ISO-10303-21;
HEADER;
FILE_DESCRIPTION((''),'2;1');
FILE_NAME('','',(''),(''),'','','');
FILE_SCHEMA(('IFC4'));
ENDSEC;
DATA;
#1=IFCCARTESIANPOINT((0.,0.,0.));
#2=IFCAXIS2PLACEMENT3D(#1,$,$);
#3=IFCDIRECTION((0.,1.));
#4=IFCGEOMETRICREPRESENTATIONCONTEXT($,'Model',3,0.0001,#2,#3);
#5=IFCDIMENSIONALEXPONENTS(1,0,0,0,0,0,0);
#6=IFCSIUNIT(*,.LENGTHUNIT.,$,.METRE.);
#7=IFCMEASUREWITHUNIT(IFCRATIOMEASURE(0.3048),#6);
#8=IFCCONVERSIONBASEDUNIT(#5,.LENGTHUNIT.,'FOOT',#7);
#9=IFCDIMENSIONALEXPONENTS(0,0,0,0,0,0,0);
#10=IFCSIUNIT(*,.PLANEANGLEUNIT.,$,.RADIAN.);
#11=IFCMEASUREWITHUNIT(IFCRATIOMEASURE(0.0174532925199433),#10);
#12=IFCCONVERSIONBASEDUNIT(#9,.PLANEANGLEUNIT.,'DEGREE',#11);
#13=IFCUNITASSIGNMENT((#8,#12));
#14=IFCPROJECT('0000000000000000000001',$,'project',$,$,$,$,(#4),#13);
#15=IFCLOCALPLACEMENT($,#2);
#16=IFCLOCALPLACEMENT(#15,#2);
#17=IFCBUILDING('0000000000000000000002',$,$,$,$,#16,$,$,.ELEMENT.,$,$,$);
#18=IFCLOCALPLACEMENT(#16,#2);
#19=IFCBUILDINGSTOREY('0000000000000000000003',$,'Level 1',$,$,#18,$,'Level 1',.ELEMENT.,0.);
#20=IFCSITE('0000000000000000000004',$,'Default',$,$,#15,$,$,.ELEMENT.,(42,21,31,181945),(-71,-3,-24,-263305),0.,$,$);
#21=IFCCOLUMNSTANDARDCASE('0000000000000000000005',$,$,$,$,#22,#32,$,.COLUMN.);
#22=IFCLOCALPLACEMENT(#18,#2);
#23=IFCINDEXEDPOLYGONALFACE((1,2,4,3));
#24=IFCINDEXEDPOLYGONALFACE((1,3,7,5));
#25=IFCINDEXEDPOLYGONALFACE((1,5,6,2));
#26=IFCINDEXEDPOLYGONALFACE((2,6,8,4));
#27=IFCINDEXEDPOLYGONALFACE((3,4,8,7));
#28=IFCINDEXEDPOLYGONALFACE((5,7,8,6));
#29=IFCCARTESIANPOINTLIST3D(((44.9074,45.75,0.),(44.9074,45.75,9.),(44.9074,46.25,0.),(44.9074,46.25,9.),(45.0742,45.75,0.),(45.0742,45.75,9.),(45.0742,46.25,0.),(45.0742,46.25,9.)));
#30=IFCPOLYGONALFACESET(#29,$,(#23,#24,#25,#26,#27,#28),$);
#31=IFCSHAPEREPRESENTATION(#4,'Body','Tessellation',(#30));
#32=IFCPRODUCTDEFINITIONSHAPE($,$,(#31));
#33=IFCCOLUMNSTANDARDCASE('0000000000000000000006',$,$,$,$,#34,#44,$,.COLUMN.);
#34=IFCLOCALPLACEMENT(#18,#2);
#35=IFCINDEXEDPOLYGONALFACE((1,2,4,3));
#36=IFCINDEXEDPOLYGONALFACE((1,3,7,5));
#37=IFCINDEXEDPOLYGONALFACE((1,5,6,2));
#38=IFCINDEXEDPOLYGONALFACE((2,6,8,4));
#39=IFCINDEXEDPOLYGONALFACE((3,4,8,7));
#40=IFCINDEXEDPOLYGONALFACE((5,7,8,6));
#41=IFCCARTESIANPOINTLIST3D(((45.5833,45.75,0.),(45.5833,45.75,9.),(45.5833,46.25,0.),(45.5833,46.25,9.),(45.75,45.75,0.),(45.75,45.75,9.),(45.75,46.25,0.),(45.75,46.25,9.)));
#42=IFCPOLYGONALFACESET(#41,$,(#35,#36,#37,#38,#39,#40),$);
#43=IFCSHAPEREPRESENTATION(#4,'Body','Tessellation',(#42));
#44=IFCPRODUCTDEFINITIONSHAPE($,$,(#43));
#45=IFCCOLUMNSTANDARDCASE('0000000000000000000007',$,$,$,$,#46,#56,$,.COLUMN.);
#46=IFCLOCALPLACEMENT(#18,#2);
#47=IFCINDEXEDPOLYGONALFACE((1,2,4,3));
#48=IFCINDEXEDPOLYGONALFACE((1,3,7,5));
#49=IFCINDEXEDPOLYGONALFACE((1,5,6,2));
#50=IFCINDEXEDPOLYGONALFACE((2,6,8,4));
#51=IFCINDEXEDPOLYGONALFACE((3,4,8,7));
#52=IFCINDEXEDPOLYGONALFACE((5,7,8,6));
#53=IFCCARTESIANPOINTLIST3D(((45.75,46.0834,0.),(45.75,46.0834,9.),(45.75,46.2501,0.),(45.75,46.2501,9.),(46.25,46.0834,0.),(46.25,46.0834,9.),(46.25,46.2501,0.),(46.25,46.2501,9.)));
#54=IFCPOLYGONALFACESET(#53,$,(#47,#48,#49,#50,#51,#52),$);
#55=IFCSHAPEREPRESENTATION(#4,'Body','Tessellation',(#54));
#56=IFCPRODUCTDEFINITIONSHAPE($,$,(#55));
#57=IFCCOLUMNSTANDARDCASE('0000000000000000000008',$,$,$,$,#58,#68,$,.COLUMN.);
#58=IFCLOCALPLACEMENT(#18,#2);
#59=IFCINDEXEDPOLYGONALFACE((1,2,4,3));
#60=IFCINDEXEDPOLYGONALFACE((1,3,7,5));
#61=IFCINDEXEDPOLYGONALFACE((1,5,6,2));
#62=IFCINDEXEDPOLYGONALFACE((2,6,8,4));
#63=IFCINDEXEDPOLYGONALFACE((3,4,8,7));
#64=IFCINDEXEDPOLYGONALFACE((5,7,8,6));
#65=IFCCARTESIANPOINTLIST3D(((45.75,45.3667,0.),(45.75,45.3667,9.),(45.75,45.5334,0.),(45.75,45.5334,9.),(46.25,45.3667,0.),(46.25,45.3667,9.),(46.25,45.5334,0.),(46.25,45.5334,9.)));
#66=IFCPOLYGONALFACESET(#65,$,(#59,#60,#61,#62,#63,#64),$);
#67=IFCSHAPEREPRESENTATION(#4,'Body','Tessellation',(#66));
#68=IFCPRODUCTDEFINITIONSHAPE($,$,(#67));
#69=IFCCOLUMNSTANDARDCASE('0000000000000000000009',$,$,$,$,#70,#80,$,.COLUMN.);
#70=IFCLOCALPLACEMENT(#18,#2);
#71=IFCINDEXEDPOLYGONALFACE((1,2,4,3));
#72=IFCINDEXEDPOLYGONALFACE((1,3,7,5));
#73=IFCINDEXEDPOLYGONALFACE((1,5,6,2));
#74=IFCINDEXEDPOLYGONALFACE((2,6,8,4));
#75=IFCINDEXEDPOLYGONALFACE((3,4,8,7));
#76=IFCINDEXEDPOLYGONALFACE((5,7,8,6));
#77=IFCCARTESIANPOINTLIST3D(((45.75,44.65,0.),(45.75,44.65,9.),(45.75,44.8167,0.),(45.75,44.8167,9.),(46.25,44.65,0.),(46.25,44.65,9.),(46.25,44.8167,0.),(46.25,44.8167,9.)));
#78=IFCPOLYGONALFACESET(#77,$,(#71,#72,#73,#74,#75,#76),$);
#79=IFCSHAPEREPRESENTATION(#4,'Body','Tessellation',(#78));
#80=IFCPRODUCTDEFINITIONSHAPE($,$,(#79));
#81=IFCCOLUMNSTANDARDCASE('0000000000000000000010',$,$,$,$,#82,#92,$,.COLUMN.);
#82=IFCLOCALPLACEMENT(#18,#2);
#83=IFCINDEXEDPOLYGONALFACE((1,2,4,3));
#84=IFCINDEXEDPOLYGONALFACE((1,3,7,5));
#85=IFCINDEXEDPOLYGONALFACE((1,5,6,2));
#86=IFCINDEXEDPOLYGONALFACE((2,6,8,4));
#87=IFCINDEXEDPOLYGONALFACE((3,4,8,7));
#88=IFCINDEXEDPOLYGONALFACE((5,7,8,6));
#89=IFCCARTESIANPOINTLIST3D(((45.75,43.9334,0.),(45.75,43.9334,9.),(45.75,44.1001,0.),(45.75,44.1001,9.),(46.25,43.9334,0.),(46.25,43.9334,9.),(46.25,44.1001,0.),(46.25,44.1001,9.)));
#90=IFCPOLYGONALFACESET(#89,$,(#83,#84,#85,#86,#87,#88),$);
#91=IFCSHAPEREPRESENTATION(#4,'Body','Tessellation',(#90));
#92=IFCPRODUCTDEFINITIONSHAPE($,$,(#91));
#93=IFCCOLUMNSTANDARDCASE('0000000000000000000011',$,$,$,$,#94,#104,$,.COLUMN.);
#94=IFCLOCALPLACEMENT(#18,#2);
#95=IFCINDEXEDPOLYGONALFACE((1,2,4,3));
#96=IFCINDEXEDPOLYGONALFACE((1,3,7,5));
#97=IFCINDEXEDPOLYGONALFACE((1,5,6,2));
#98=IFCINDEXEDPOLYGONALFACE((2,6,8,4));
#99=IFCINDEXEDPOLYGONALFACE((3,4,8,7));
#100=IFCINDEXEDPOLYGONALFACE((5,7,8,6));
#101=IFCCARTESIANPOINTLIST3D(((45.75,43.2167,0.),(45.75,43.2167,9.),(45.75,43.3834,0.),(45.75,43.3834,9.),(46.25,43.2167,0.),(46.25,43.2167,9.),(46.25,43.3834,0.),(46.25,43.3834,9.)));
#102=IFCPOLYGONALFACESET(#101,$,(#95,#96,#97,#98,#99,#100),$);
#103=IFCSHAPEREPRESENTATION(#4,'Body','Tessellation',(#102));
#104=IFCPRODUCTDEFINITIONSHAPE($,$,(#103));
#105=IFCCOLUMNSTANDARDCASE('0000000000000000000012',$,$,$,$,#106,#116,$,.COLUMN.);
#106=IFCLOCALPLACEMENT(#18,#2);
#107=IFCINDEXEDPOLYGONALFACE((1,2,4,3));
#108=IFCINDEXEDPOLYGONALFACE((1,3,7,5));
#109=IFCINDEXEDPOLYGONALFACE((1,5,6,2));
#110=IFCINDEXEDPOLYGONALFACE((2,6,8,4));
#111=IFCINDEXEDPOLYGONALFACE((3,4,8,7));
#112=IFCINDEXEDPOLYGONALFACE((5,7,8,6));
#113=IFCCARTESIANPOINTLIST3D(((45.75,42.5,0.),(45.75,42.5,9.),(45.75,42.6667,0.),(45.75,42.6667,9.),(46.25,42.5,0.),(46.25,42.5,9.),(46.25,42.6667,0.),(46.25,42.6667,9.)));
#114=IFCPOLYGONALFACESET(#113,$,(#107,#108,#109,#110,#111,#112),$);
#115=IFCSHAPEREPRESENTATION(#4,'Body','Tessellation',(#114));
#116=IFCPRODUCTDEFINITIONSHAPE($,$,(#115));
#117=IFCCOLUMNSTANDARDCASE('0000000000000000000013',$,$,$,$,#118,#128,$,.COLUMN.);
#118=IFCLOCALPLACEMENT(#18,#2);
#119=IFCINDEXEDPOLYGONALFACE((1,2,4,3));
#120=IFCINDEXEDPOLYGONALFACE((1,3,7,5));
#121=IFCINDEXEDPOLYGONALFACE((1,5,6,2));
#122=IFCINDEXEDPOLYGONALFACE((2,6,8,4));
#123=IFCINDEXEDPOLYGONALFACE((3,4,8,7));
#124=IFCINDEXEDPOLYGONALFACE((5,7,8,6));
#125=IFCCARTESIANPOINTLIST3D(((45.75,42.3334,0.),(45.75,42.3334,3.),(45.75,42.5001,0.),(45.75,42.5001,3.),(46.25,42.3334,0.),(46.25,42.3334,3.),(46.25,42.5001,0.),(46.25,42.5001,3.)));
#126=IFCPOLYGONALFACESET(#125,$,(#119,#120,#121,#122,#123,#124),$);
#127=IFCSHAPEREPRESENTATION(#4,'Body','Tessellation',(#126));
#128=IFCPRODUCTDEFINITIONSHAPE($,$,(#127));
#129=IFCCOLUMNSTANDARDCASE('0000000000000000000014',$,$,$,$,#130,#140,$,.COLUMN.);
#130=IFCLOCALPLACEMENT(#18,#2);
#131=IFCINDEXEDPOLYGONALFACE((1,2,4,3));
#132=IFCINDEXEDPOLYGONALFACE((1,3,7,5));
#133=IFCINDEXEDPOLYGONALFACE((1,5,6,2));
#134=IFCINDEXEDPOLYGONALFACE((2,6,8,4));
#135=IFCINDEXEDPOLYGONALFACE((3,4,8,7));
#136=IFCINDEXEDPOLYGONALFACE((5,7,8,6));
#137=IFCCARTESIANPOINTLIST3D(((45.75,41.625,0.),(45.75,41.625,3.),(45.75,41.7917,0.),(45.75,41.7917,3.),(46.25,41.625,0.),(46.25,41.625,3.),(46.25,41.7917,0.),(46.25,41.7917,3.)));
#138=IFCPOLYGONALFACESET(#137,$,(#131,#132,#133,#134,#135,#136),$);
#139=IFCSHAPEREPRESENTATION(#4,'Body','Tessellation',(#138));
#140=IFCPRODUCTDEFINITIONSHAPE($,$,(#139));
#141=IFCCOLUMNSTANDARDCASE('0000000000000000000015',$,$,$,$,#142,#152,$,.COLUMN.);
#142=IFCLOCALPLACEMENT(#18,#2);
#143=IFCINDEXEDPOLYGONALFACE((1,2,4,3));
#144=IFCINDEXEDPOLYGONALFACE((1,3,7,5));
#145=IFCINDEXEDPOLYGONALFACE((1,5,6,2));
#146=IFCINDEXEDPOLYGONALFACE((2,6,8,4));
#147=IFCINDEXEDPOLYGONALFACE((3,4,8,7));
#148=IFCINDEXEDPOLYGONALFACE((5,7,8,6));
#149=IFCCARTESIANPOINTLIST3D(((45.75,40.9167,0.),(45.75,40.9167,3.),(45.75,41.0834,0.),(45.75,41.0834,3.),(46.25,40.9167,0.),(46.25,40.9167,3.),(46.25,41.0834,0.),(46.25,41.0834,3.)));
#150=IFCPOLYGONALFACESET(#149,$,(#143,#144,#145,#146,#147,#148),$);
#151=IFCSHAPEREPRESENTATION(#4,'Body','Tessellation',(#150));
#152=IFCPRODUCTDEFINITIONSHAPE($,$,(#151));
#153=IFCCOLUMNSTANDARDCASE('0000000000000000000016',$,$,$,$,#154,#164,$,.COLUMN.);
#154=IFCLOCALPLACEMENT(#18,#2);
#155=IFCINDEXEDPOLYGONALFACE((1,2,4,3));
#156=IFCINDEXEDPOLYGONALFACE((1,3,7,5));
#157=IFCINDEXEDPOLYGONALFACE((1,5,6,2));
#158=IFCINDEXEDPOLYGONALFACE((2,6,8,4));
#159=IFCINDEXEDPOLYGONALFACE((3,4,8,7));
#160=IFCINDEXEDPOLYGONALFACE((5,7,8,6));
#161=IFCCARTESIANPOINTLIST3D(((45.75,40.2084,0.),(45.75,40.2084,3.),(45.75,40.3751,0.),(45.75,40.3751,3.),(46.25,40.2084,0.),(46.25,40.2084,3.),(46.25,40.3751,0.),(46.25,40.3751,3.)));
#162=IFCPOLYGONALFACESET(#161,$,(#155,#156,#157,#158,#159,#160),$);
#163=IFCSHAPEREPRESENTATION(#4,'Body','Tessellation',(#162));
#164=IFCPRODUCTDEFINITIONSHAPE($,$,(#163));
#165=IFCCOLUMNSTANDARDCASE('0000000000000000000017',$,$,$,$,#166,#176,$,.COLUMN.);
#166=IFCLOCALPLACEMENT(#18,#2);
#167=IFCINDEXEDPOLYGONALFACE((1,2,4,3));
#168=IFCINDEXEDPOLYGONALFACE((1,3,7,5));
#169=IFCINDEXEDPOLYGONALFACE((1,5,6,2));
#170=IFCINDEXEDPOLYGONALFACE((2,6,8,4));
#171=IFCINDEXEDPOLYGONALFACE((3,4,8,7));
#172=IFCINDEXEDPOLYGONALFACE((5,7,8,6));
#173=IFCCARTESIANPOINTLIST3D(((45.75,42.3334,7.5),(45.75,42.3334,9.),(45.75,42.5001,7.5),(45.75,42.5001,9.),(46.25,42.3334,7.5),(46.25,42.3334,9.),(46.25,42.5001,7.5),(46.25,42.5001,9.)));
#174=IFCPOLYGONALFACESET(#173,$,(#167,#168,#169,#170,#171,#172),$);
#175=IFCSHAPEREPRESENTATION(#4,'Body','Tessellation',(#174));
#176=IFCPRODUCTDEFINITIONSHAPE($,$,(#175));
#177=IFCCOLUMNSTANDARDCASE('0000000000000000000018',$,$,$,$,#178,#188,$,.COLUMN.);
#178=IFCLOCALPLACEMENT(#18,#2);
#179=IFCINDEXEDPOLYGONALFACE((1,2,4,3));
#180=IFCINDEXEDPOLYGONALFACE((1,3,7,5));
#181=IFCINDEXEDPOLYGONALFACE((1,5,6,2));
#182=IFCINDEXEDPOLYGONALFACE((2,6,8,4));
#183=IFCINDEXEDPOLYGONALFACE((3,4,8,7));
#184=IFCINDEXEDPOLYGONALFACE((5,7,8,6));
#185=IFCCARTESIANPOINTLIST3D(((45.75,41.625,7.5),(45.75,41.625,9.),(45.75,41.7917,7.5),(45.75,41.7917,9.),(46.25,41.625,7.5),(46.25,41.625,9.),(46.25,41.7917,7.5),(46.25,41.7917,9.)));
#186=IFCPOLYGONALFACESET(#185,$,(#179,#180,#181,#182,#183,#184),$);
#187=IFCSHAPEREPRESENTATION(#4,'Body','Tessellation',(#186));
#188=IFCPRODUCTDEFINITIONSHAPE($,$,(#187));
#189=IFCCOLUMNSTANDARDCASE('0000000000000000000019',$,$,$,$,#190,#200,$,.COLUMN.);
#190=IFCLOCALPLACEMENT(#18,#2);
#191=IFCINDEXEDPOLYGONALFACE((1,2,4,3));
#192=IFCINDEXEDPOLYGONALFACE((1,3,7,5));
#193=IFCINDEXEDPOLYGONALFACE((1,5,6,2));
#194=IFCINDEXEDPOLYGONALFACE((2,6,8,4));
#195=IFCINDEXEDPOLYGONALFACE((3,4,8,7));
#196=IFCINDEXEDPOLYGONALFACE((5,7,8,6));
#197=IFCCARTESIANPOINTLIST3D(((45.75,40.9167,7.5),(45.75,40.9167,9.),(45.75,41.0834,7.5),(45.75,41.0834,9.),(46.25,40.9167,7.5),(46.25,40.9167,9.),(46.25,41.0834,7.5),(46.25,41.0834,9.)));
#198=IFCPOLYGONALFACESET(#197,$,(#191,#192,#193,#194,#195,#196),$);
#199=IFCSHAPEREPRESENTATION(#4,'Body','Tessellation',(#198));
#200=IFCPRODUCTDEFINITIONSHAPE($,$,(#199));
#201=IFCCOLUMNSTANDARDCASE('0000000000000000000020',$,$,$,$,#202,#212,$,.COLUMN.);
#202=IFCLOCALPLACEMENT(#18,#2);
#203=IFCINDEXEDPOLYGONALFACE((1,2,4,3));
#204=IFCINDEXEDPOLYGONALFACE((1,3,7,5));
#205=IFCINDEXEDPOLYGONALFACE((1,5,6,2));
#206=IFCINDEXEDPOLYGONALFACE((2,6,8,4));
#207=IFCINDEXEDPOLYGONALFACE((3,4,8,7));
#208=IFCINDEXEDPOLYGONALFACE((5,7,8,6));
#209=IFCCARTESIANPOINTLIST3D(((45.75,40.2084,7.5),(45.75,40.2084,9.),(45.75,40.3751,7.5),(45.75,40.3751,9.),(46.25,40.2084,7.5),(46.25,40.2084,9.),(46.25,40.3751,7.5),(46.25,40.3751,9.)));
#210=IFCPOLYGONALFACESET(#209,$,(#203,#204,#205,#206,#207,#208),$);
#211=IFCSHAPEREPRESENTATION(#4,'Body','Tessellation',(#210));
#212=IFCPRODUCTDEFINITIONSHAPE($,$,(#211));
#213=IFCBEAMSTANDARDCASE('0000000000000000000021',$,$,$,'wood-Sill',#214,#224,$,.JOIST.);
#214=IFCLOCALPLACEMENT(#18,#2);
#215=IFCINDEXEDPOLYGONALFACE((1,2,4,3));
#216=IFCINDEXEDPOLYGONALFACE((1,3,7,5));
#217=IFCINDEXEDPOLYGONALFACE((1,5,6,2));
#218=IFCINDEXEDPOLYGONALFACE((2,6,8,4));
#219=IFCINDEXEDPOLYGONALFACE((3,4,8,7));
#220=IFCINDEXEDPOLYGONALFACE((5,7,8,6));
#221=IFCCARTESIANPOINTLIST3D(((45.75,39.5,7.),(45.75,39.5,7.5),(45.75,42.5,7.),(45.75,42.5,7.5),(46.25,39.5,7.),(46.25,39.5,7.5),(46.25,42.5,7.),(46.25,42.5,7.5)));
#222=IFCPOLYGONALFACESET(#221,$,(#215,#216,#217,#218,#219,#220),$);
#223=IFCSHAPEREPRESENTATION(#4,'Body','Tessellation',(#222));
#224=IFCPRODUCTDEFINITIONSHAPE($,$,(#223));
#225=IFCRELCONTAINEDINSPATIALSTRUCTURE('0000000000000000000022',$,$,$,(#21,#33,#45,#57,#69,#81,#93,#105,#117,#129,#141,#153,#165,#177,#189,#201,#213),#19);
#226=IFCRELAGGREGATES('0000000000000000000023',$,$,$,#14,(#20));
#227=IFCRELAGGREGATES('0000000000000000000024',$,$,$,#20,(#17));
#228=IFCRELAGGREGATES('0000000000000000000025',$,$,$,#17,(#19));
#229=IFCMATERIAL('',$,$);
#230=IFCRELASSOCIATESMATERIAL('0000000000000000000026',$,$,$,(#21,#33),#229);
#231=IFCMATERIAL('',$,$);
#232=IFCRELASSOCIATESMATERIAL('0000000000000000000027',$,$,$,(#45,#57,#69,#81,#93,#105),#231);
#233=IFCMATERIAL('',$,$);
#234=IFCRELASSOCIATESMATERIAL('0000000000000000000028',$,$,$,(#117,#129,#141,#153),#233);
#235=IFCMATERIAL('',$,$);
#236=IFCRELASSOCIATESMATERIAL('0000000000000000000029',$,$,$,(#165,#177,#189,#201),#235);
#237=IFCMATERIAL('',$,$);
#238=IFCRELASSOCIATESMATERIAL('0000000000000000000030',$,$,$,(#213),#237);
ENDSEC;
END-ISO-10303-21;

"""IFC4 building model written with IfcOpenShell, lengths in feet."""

from ifc_helpers import new_model, entity, si_unit, converted_unit, direction, frame, origin, place, context, project, spatial, rectangle, extrude, material, element, save


model = new_model("IFC4")

# Units and contexts
model_context = context("Model", 3, precision=0.0001, world=origin(), true_north=direction((0.0, 1.0)))
ifc_project = project(units=[converted_unit("LENGTHUNIT", "FOOT", entity("IfcRatioMeasure", 0.3048), si_unit("LENGTHUNIT", "METRE"), dimensions=[1, 0, 0, 0, 0, 0, 0]), converted_unit("PLANEANGLEUNIT", "DEGREE", entity("IfcRatioMeasure", 0.0174532925199433), si_unit("PLANEANGLEUNIT", "RADIAN"), dimensions=[0, 0, 0, 0, 0, 0, 0])], contexts=[model_context])

# Site, building, storey
site_placement = place(None, origin())
site = spatial("IfcSite", under=ifc_project, at=site_placement, Name="Default", CompositionType="ELEMENT", RefLatitude=(42, 21, 31, 181945), RefLongitude=(-71, -3, -24, -263305), RefElevation=0.0)
building_placement = place(site_placement, origin())
building = spatial("IfcBuilding", under=site, at=building_placement, CompositionType="ELEMENT")
storey_placement = place(building_placement, origin())
storey = spatial("IfcBuildingStorey", under=building, at=storey_placement, Name="Level 1", LongName="Level 1", CompositionType="ELEMENT", Elevation=0.0)

# Columns
ifc_material_1 = material(Name="")
placement_1 = place(storey_placement, frame((-0.25, 46.0, 0.0)))
for number, where, z_axis, x_axis in (
    (1, (45.2408, 0.0, 0.0), (0.0, 0.0, 1.0), (1.0, 0.0, 0.0)),
    (2, (45.9167, 0.0, 0.0), (0.0, 0.0, 1.0), (1.0, 0.0, 0.0)),
):
    element("IfcColumnStandardCase", number, at=place(placement_1, frame(where, z_axis=z_axis, x_axis=x_axis)), inside=storey, material=ifc_material_1, PredefinedType="COLUMN", context=model_context, shape_type="SweptSolid", body=[
        extrude(rectangle(XDim=0.1667, YDim=0.5), origin(), (0.0, 0.0, 1.0), 9.0),
    ])
ifc_material_2 = material(Name="")
placement_2 = place(storey_placement, frame((46.0, 46.25, 0.0), z_axis=(0.0, 0.0, 1.0), x_axis=(0.0, -1.0, 0.0)))
for number, where, z_axis, x_axis in (
    (3, (0.0833, 0.0, 0.0), (0.0, 0.0, 1.0), (1.0, 0.0, 0.0)),
    (4, (0.8, 0.0, 0.0), (0.0, 0.0, 1.0), (1.0, 0.0, 0.0)),
    (5, (1.5167, 0.0, 0.0), (0.0, 0.0, 1.0), (1.0, 0.0, 0.0)),
    (6, (2.2333, 0.0, 0.0), (0.0, 0.0, 1.0), (1.0, 0.0, 0.0)),
    (7, (2.95, 0.0, 0.0), (0.0, 0.0, 1.0), (1.0, 0.0, 0.0)),
    (8, (3.6667, 0.0, 0.0), (0.0, 0.0, 1.0), (1.0, 0.0, 0.0)),
):
    element("IfcColumnStandardCase", number, at=place(placement_2, frame(where, z_axis=z_axis, x_axis=x_axis)), inside=storey, material=ifc_material_2, PredefinedType="COLUMN", context=model_context, shape_type="SweptSolid", body=[
        extrude(rectangle(XDim=0.1667, YDim=0.5), origin(), (0.0, 0.0, 1.0), 9.0),
    ])
ifc_material_3 = material(Name="")
for number, where, z_axis, x_axis in (
    (9, (3.8333, 0.0, 0.0), (0.0, 0.0, 1.0), (1.0, 0.0, 0.0)),
    (10, (4.5417, 0.0, 0.0), (0.0, 0.0, 1.0), (1.0, 0.0, 0.0)),
    (11, (5.25, 0.0, 0.0), (0.0, 0.0, 1.0), (1.0, 0.0, 0.0)),
    (12, (5.9583, 0.0, 0.0), (0.0, 0.0, 1.0), (1.0, 0.0, 0.0)),
):
    element("IfcColumnStandardCase", number, at=place(placement_2, frame(where, z_axis=z_axis, x_axis=x_axis)), inside=storey, material=ifc_material_3, PredefinedType="COLUMN", context=model_context, shape_type="SweptSolid", body=[
        extrude(rectangle(XDim=0.1667, YDim=0.5), origin(), (0.0, 0.0, 1.0), 3.0),
    ])
ifc_material_4 = material(Name="")
for number, where, z_axis, x_axis in (
    (13, (3.8333, 0.0, 7.5), (0.0, 0.0, 1.0), (1.0, 0.0, 0.0)),
    (14, (4.5417, 0.0, 7.5), (0.0, 0.0, 1.0), (1.0, 0.0, 0.0)),
    (15, (5.25, 0.0, 7.5), (0.0, 0.0, 1.0), (1.0, 0.0, 0.0)),
    (16, (5.9583, 0.0, 7.5), (0.0, 0.0, 1.0), (1.0, 0.0, 0.0)),
):
    element("IfcColumnStandardCase", number, at=place(placement_2, frame(where, z_axis=z_axis, x_axis=x_axis)), inside=storey, material=ifc_material_4, PredefinedType="COLUMN", context=model_context, shape_type="SweptSolid", body=[
        extrude(rectangle(XDim=0.1667, YDim=0.5), origin(), (0.0, 0.0, 1.0), 1.5),
    ])

# Beam
ifc_material_5 = material(Name="")
for number, where, z_axis, x_axis in (
    (17, (5.25, 0.0, 7.0), (0.0, 0.0, 1.0), (1.0, 0.0, 0.0)),
):
    element("IfcBeamStandardCase", number, at=place(placement_2, frame(where, z_axis=z_axis, x_axis=x_axis)), inside=storey, material=ifc_material_5, ObjectType="wood-Sill", PredefinedType="JOIST", context=model_context, shape_type="SweptSolid", body=[
        extrude(rectangle(XDim=3.0, YDim=0.5), origin(), (0.0, 0.0, 1.0), 0.5),
    ])

save(model, "model.ifc")
